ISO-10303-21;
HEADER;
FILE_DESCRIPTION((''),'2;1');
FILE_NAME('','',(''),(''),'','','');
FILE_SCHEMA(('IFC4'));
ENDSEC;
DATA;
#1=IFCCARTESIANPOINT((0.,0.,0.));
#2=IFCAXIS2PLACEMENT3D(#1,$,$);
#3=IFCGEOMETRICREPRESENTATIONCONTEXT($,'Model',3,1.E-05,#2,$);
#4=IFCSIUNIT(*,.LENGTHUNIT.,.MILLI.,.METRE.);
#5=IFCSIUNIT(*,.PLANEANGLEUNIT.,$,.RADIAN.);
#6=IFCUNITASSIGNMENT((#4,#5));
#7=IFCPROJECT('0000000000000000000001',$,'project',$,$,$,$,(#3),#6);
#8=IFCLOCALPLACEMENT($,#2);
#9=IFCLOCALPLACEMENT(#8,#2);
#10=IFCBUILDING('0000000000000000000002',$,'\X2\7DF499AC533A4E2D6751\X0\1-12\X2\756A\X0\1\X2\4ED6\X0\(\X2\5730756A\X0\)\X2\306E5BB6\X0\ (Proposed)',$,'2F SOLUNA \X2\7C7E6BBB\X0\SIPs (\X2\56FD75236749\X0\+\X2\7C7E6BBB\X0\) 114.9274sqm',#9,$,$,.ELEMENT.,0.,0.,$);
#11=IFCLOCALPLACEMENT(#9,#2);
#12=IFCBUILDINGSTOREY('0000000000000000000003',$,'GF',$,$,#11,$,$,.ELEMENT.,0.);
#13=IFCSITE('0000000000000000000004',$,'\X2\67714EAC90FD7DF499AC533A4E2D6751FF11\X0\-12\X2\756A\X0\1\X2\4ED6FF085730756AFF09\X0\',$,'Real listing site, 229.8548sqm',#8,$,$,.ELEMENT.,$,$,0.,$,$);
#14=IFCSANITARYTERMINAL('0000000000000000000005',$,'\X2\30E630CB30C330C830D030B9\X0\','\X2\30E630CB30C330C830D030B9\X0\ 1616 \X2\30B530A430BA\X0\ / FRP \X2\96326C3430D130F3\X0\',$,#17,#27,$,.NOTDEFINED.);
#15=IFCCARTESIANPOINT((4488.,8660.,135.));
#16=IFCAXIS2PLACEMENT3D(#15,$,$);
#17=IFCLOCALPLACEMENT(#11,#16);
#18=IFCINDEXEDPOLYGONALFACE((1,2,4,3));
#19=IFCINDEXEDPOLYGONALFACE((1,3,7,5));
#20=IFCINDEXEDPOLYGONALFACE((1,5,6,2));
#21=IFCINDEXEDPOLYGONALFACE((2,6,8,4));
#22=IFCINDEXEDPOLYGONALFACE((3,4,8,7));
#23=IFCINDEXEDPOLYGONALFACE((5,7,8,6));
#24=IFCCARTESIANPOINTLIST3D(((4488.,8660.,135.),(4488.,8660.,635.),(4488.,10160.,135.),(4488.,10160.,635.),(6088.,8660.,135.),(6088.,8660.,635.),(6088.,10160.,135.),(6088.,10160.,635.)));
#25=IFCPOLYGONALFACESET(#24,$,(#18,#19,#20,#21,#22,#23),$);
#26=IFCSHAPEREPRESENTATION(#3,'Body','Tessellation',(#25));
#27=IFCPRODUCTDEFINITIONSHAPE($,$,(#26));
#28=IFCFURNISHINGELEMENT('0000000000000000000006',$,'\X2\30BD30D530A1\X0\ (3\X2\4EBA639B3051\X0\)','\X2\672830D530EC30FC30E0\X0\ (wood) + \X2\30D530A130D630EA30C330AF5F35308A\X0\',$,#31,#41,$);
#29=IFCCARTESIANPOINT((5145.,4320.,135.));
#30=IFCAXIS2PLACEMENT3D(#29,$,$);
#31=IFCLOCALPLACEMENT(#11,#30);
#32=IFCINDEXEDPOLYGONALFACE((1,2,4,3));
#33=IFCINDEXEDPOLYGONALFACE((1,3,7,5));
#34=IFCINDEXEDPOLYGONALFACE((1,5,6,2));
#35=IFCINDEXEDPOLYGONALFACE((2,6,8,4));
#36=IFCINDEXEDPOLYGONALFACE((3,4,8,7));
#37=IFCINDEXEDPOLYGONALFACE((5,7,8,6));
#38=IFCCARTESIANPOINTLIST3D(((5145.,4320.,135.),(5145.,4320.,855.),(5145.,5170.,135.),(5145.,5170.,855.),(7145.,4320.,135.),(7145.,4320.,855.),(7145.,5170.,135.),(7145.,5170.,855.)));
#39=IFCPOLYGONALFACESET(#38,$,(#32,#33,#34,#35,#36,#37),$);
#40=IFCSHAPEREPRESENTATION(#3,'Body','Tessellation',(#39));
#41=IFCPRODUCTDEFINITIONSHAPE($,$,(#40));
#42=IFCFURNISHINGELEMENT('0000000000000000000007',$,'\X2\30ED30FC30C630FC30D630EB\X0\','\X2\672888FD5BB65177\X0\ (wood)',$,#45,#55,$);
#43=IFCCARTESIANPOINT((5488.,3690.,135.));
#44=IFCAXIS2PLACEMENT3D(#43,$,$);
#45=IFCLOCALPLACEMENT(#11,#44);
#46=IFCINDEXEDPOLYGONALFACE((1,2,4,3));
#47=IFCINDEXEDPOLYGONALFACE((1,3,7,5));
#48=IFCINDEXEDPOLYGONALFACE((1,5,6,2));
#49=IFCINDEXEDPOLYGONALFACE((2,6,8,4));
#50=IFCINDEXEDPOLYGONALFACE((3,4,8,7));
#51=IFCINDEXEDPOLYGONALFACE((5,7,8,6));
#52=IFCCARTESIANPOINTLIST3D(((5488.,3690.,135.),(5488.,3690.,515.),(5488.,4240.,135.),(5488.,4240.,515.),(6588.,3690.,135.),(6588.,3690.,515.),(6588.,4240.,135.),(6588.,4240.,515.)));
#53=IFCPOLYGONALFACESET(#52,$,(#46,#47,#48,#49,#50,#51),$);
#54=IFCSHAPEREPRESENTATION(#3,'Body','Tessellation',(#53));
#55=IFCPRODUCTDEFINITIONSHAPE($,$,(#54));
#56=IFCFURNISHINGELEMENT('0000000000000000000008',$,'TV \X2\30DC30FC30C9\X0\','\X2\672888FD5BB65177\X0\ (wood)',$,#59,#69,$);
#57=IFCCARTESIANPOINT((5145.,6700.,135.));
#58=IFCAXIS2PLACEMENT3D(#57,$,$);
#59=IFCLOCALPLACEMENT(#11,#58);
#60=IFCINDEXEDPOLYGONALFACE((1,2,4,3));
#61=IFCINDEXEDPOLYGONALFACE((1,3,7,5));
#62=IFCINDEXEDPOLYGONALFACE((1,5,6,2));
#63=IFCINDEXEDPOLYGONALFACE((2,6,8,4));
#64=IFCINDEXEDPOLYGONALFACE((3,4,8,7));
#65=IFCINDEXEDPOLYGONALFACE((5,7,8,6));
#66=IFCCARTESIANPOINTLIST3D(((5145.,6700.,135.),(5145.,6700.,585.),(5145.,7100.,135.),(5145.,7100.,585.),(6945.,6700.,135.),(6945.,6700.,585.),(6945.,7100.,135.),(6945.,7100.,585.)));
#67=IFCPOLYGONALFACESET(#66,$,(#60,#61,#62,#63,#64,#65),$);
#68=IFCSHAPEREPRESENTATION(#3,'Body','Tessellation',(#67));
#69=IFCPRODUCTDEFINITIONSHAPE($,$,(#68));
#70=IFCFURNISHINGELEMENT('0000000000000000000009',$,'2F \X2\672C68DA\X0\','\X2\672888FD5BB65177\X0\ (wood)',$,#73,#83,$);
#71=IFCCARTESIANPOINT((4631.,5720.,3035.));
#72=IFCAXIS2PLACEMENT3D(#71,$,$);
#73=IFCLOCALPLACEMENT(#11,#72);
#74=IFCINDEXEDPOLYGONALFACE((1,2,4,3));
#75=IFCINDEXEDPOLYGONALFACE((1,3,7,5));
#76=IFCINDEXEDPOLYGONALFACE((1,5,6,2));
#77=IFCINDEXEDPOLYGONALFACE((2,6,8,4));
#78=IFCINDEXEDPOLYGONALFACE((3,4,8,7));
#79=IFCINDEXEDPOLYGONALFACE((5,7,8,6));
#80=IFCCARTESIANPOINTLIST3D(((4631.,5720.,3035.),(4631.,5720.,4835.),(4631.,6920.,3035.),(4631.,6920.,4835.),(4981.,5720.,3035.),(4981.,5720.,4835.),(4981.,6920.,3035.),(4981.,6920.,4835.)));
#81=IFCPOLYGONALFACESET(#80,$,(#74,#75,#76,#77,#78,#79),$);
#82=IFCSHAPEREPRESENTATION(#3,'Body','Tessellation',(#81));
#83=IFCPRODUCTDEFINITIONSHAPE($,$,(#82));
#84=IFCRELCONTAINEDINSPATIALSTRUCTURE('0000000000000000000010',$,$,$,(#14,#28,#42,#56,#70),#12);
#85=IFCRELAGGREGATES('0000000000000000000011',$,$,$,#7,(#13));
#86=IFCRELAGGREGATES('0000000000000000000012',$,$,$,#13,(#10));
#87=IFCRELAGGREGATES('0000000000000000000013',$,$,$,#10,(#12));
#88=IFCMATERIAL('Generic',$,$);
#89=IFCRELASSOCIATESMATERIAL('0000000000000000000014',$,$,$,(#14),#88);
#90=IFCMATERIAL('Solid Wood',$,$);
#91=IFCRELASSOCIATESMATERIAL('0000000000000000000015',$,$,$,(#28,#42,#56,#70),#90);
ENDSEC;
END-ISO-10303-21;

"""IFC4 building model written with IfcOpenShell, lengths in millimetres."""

from ifc_helpers import new_model, si_unit, frame, frame_2d, origin, place, context, project, spatial, rectangle, extrude, material, element, save


model = new_model("IFC4")

# Units and contexts
model_context = context("Model", 3, precision=1e-05, world=origin())
ifc_project = project(units=[si_unit("LENGTHUNIT", "METRE", prefix="MILLI"), si_unit("PLANEANGLEUNIT", "RADIAN")], contexts=[model_context])

# Site, building, storey
site_placement = place(None, origin())
site = spatial("IfcSite", under=ifc_project, at=site_placement, Name="東京都練馬区中村１-12番1他（地番）", ObjectType="Real listing site, 229.8548sqm", CompositionType="ELEMENT", RefElevation=0.0)
building_placement = place(site_placement, origin())
building = spatial("IfcBuilding", under=site, at=building_placement, Name="練馬区中村1-12番1他(地番)の家 (Proposed)", ObjectType="2F SOLUNA 籾殻SIPs (国産杉+籾殻) 114.9274sqm", CompositionType="ELEMENT", ElevationOfRefHeight=0.0, ElevationOfTerrain=0.0)
storey_placement = place(building_placement, origin())
storey = spatial("IfcBuildingStorey", under=building, at=storey_placement, Name="GF", CompositionType="ELEMENT", Elevation=0.0)

# Shared definitions
ifc_material_1 = material(Name="Solid Wood")

# Sanitary terminal
ifc_material_2 = material(Name="Generic")
sanitary_terminal_placement = place(storey_placement, frame((4488.0, 8660.0, 135.0)))
element("IfcSanitaryTerminal", 1, at=sanitary_terminal_placement, inside=storey, material=ifc_material_2, Name="ユニットバス", Description="ユニットバス 1616 サイズ / FRP 防水パン", PredefinedType="NOTDEFINED", context=model_context, shape_type="SweptSolid", body=[
    extrude(rectangle(XDim=1600.0, YDim=1500.0, at=frame_2d((800.0, 750.0))), frame((4488.0, 8660.0, 135.0)), (0.0, 0.0, 1.0), 500.0),
])

# Furnishing elements
furnishing_1_placement = place(storey_placement, frame((5145.0, 4320.0, 135.0)))
element("IfcFurnishingElement", 2, at=furnishing_1_placement, inside=storey, material=ifc_material_1, Name="ソファ (3人掛け)", Description="木フレーム (wood) + ファブリック張り", context=model_context, shape_type="SweptSolid", body=[
    extrude(rectangle(XDim=2000.0, YDim=850.0, at=frame_2d((1000.0, 425.0))), frame((5145.0, 4320.0, 135.0)), (0.0, 0.0, 1.0), 720.0),
])
furnishing_2_placement = place(storey_placement, frame((5488.0, 3690.0, 135.0)))
element("IfcFurnishingElement", 3, at=furnishing_2_placement, inside=storey, material=ifc_material_1, Name="ローテーブル", Description="木製家具 (wood)", context=model_context, shape_type="SweptSolid", body=[
    extrude(rectangle(XDim=1100.0, YDim=550.0, at=frame_2d((550.0, 275.0))), frame((5488.0, 3690.0, 135.0)), (0.0, 0.0, 1.0), 380.0),
])
furnishing_3_placement = place(storey_placement, frame((5145.0, 6700.0, 135.0)))
element("IfcFurnishingElement", 4, at=furnishing_3_placement, inside=storey, material=ifc_material_1, Name="TV ボード", Description="木製家具 (wood)", context=model_context, shape_type="SweptSolid", body=[
    extrude(rectangle(XDim=1800.0, YDim=400.0, at=frame_2d((900.0, 200.0))), frame((5145.0, 6700.0, 135.0)), (0.0, 0.0, 1.0), 450.0),
])
furnishing_4_placement = place(storey_placement, frame((4631.0, 5720.0, 3035.0)))
element("IfcFurnishingElement", 5, at=furnishing_4_placement, inside=storey, material=ifc_material_1, Name="2F 本棚", Description="木製家具 (wood)", context=model_context, shape_type="SweptSolid", body=[
    extrude(rectangle(XDim=350.0, YDim=1200.0, at=frame_2d((175.0, 600.0))), frame((4631.0, 5720.0, 3035.0)), (0.0, 0.0, 1.0), 1800.0),
])

save(model, "model.ifc")
